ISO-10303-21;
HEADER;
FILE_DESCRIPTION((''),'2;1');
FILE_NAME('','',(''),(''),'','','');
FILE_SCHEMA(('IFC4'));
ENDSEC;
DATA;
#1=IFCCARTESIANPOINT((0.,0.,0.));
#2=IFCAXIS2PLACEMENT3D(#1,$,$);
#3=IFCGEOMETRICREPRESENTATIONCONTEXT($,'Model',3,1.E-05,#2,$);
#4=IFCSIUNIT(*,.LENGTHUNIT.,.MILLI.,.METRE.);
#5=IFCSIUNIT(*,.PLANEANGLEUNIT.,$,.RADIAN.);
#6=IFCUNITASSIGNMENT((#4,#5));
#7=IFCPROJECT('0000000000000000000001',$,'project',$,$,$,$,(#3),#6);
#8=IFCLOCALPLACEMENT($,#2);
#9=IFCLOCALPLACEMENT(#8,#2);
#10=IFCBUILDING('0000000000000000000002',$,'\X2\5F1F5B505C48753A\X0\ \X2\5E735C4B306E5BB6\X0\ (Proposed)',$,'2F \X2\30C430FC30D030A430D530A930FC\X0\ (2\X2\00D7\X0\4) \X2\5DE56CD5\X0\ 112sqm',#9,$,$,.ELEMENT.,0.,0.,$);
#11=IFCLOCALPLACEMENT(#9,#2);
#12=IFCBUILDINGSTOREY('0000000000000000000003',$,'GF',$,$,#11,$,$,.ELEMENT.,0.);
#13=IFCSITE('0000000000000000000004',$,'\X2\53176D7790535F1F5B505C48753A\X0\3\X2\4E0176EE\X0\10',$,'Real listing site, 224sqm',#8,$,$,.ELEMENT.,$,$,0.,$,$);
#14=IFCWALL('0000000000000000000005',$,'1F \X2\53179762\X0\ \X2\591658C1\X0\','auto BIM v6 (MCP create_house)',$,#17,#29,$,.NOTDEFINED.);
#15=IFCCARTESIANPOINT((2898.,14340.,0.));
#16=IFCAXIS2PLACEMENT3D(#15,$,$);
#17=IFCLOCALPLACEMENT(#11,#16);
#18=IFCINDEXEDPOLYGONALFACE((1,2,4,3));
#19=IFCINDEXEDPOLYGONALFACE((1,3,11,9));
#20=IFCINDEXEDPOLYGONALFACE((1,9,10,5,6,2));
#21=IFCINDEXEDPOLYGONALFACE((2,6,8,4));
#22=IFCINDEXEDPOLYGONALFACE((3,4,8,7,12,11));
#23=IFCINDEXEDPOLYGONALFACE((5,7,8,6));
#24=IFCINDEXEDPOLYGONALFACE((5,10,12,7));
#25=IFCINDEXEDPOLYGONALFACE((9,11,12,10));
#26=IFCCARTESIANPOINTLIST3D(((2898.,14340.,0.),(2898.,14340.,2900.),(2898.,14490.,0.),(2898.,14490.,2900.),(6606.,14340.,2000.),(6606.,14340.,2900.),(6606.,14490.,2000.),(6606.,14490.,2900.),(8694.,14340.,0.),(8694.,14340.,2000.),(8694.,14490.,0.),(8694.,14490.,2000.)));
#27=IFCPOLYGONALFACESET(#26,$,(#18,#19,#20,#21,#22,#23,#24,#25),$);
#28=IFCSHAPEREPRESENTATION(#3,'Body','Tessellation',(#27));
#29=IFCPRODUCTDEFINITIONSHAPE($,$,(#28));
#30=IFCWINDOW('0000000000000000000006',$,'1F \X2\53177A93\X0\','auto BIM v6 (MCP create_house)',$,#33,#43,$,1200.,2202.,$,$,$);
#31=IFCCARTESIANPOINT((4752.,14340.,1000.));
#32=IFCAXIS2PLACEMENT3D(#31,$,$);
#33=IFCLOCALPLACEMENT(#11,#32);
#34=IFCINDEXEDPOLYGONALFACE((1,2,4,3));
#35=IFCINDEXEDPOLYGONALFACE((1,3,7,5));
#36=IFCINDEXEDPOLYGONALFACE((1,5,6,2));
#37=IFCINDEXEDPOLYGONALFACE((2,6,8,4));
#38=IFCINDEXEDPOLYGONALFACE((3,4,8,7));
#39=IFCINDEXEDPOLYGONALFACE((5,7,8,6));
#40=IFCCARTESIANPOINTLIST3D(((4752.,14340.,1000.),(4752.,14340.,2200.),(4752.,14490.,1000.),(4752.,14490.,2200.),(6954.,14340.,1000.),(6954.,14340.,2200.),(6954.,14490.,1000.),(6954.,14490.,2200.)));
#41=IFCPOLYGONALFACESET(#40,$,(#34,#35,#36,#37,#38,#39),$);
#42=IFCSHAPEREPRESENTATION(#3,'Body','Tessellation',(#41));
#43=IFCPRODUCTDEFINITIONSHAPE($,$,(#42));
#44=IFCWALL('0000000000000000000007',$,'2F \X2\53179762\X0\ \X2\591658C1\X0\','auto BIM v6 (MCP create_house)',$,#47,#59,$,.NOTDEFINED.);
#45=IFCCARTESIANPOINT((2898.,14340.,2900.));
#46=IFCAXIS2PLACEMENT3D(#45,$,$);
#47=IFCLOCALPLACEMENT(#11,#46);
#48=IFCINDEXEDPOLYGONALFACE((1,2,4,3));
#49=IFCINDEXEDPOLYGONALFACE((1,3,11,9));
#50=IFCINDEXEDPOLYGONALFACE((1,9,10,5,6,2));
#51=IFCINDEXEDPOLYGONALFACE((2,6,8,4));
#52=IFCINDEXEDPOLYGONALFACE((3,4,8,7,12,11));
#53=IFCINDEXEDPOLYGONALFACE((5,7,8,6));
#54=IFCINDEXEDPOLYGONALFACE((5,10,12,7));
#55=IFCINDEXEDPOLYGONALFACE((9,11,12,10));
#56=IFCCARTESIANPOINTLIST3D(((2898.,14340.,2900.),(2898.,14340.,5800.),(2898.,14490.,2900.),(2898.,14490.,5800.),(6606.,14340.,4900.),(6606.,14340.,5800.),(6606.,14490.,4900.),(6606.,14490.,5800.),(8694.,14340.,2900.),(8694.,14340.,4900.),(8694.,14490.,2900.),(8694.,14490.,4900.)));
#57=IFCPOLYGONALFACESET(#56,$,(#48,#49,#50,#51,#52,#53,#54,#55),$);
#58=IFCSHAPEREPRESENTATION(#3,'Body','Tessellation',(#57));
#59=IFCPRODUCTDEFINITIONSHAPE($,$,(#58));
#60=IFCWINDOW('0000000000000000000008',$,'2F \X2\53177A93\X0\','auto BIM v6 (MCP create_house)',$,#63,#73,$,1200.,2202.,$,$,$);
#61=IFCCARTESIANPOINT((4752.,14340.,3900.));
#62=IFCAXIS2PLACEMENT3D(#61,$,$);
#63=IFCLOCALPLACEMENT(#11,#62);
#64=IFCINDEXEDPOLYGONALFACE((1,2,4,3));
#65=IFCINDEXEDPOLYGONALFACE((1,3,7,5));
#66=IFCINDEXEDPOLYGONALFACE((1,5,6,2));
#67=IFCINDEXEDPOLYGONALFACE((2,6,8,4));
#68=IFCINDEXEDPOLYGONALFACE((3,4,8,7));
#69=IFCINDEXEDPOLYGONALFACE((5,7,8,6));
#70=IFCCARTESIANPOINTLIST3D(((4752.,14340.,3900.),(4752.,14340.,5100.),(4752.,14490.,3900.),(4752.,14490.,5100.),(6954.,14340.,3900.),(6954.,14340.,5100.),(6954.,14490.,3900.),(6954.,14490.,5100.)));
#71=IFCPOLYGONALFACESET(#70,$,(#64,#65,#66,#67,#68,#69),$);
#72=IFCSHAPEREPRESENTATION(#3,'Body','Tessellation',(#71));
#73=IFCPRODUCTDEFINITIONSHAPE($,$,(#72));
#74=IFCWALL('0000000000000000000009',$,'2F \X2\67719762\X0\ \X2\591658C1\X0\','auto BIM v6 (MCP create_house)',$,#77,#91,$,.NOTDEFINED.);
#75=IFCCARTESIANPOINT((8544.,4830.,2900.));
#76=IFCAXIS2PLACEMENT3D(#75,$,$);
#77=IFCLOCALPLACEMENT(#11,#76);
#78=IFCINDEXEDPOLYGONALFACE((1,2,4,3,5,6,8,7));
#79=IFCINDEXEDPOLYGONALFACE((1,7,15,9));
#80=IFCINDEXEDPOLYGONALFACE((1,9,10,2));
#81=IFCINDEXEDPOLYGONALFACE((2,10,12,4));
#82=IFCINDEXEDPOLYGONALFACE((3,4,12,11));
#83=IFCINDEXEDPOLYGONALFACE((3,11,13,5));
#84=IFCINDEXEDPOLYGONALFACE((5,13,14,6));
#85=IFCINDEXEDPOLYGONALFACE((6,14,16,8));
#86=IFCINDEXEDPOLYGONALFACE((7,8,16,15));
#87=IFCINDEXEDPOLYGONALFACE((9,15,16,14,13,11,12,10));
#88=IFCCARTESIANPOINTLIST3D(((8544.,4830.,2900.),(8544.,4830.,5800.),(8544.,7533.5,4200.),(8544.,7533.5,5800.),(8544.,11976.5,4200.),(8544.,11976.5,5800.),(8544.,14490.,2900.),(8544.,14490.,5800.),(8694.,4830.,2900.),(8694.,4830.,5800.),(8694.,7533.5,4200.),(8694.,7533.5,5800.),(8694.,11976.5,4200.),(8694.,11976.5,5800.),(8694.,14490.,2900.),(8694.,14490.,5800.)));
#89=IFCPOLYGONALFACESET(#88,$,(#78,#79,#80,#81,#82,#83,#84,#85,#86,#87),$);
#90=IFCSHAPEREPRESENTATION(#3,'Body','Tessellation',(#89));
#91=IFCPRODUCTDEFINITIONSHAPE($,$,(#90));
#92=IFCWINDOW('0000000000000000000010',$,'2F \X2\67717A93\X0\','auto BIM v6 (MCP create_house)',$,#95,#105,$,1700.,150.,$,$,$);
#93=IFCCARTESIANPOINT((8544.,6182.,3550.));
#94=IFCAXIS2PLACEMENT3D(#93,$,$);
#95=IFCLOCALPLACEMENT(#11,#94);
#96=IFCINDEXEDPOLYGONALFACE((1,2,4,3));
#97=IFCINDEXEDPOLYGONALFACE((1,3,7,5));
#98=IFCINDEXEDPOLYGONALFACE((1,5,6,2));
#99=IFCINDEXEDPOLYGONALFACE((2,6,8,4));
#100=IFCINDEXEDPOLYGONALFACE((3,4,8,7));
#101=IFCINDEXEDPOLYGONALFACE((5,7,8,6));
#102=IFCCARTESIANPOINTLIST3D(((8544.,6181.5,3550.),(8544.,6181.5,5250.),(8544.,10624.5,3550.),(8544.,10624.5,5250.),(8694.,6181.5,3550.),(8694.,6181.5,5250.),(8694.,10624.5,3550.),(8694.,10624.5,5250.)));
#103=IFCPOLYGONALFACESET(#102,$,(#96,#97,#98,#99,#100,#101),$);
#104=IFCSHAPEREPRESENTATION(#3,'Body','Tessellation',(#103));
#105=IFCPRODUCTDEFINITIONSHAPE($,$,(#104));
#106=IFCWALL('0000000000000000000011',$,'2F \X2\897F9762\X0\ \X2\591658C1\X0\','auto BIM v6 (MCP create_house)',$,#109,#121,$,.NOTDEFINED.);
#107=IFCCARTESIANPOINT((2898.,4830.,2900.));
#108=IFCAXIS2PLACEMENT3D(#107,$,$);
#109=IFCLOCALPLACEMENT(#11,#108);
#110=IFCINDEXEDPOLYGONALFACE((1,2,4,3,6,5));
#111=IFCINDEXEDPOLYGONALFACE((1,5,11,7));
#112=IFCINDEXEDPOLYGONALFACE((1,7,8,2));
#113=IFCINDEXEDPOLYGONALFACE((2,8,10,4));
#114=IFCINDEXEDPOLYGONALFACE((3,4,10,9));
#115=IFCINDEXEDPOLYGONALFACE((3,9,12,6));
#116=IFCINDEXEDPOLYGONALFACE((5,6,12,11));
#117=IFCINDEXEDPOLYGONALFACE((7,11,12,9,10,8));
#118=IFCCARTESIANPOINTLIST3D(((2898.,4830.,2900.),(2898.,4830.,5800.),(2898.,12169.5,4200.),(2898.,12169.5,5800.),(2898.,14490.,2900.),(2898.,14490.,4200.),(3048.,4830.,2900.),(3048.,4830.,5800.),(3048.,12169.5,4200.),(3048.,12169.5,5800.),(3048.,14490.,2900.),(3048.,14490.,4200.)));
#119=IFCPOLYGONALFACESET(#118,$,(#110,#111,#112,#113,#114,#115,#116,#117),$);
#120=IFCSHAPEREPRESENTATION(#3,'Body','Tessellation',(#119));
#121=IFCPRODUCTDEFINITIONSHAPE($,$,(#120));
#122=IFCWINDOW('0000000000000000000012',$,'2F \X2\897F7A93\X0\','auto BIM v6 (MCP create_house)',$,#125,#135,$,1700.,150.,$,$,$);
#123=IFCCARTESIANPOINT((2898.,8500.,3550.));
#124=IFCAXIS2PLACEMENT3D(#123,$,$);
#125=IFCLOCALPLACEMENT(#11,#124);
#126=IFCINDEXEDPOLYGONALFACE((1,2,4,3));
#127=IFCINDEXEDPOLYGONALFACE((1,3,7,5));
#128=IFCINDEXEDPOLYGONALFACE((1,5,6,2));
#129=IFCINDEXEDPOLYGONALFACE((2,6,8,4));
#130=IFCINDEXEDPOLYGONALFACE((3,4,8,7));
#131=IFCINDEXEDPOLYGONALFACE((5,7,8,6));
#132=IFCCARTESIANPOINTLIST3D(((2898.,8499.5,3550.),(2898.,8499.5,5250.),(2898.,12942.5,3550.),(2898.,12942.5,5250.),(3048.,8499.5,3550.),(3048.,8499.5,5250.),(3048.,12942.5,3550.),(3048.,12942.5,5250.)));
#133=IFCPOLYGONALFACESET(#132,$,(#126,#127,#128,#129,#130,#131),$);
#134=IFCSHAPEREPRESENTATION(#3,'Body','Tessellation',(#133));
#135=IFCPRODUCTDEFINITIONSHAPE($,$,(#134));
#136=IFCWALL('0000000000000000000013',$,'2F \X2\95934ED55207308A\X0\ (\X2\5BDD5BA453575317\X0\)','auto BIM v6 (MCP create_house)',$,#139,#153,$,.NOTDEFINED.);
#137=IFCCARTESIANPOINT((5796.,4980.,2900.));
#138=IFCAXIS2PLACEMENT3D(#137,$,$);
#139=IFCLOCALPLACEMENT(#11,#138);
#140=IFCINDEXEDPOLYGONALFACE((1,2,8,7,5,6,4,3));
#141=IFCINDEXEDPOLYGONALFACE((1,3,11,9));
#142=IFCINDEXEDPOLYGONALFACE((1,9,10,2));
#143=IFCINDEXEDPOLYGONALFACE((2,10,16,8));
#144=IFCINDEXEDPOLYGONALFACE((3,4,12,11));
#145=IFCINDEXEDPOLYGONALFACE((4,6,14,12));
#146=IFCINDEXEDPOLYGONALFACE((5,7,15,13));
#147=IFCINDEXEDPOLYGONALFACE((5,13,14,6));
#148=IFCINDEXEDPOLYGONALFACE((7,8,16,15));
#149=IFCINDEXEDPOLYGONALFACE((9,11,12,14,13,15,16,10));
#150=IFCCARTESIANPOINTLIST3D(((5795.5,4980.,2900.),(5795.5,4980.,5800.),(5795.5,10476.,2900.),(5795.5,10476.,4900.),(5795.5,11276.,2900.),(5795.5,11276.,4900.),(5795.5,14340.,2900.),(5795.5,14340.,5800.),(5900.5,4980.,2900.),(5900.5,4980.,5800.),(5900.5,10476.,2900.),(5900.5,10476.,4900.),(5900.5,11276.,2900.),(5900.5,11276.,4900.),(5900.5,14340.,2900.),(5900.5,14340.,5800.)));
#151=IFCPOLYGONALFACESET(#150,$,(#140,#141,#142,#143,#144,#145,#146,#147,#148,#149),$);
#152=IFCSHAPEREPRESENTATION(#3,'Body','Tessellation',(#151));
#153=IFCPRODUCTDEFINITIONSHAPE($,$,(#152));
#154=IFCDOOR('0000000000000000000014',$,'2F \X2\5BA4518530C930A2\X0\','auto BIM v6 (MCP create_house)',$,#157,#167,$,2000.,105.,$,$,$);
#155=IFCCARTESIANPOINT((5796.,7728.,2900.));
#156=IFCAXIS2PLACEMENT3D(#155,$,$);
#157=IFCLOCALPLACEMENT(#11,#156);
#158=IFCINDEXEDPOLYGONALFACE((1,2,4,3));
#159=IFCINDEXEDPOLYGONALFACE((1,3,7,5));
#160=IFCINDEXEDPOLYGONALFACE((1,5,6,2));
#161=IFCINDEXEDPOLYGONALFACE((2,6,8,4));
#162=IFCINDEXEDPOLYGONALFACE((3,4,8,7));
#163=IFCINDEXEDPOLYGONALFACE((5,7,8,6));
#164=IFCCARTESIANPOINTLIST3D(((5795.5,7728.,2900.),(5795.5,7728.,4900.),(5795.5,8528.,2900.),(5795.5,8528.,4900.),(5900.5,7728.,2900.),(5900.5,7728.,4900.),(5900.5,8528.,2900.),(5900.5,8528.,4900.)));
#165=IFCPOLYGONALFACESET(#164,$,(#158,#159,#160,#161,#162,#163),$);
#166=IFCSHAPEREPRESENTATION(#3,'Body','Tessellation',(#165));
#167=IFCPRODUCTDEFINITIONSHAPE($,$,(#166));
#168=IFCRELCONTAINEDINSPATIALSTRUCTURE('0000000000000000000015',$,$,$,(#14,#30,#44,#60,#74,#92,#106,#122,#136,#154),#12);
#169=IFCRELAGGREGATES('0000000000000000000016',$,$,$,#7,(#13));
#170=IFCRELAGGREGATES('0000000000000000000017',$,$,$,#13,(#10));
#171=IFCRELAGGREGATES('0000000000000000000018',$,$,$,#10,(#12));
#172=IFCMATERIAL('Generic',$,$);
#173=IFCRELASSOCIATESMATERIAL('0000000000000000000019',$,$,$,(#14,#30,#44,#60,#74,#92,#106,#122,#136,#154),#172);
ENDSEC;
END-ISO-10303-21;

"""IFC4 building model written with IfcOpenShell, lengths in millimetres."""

from ifc_helpers import new_model, si_unit, frame, frame_2d, origin, place, context, project, spatial, rectangle, extrude, material, element, fill, save


model = new_model("IFC4")

# Units and contexts
model_context = context("Model", 3, precision=1e-05, world=origin())
ifc_project = project(units=[si_unit("LENGTHUNIT", "METRE", prefix="MILLI"), si_unit("PLANEANGLEUNIT", "RADIAN")], contexts=[model_context])

# Site, building, storey
site_placement = place(None, origin())
site = spatial("IfcSite", under=ifc_project, at=site_placement, Name="北海道弟子屈町3丁目10", ObjectType="Real listing site, 224sqm", CompositionType="ELEMENT", RefElevation=0.0)
building_placement = place(site_placement, origin())
building = spatial("IfcBuilding", under=site, at=building_placement, Name="弟子屈町 平屋の家 (Proposed)", ObjectType="2F ツーバイフォー (2×4) 工法 112sqm", CompositionType="ELEMENT", ElevationOfRefHeight=0.0, ElevationOfTerrain=0.0)
storey_placement = place(building_placement, origin())
storey = spatial("IfcBuildingStorey", under=building, at=storey_placement, Name="GF", CompositionType="ELEMENT", Elevation=0.0)

# Wall, opening, window
ifc_material = material(Name="Generic")
wall_1_placement = place(storey_placement, frame((2898.0, 14340.0, 0.0)))
wall_1 = element("IfcWall", 1, at=wall_1_placement, inside=storey, material=ifc_material, Name="1F 北面 外壁", Description="auto BIM v6 (MCP create_house)", PredefinedType="NOTDEFINED", context=model_context, shape_type="SweptSolid", body=[
    extrude(rectangle(XDim=5796.0, YDim=150.0, at=frame_2d((2898.0, 75.0))), frame((2898.0, 14340.0, 0.0)), (0.0, 0.0, 1.0), 2900.0),
])
opening_1_placement = place(storey_placement, frame((4752.0, 14340.0, 1000.0)))
opening_1 = element("IfcOpeningElement", 2, at=opening_1_placement, cuts=wall_1, PredefinedType="NOTDEFINED", context=model_context, shape_type="SweptSolid", body=[
    extrude(rectangle(XDim=2202.0, YDim=150.0, at=frame_2d((1101.0, 75.0))), frame((4752.0, 14340.0, 1000.0)), (0.0, 0.0, 1.0), 1200.0),
])
window_1_placement = place(storey_placement, frame((4752.0, 14340.0, 1000.0)))
window_1 = element("IfcWindow", 3, at=window_1_placement, inside=storey, material=ifc_material, Name="1F 北窓", Description="auto BIM v6 (MCP create_house)", OverallHeight=1200.0, OverallWidth=2202.0, context=model_context, shape_type="SweptSolid", body=[
    extrude(rectangle(XDim=2202.0, YDim=150.0, at=frame_2d((1101.0, 75.0))), frame((4752.0, 14340.0, 1000.0)), (0.0, 0.0, 1.0), 1200.0),
])
fill(opening_1, window_1)

# Walls, openings, windows
wall_2_placement = place(storey_placement, frame((2898.0, 14340.0, 2900.0)))
wall_2 = element("IfcWall", 4, at=wall_2_placement, inside=storey, material=ifc_material, Name="2F 北面 外壁", Description="auto BIM v6 (MCP create_house)", PredefinedType="NOTDEFINED", context=model_context, shape_type="SweptSolid", body=[
    extrude(rectangle(XDim=5796.0, YDim=150.0, at=frame_2d((2898.0, 75.0))), frame((2898.0, 14340.0, 2900.0)), (0.0, 0.0, 1.0), 2900.0),
])
opening_2_placement = place(storey_placement, frame((4752.0, 14340.0, 3900.0)))
opening_2 = element("IfcOpeningElement", 5, at=opening_2_placement, cuts=wall_2, PredefinedType="NOTDEFINED", context=model_context, shape_type="SweptSolid", body=[
    extrude(rectangle(XDim=2202.0, YDim=150.0, at=frame_2d((1101.0, 75.0))), frame((4752.0, 14340.0, 3900.0)), (0.0, 0.0, 1.0), 1200.0),
])
window_2_placement = place(storey_placement, frame((4752.0, 14340.0, 3900.0)))
window_2 = element("IfcWindow", 6, at=window_2_placement, inside=storey, material=ifc_material, Name="2F 北窓", Description="auto BIM v6 (MCP create_house)", OverallHeight=1200.0, OverallWidth=2202.0, context=model_context, shape_type="SweptSolid", body=[
    extrude(rectangle(XDim=2202.0, YDim=150.0, at=frame_2d((1101.0, 75.0))), frame((4752.0, 14340.0, 3900.0)), (0.0, 0.0, 1.0), 1200.0),
])
fill(opening_2, window_2)
wall_3_placement = place(storey_placement, frame((8544.0, 4830.0, 2900.0)))
wall_3 = element("IfcWall", 7, at=wall_3_placement, inside=storey, material=ifc_material, Name="2F 東面 外壁", Description="auto BIM v6 (MCP create_house)", PredefinedType="NOTDEFINED", context=model_context, shape_type="SweptSolid", body=[
    extrude(rectangle(XDim=150.0, YDim=9660.0, at=frame_2d((75.0, 4830.0))), frame((8544.0, 4830.0, 2900.0)), (0.0, 0.0, 1.0), 2900.0),
])
opening_3_placement = place(storey_placement, frame((8544.0, 6182.0, 3550.0)))
opening_3 = element("IfcOpeningElement", 8, at=opening_3_placement, cuts=wall_3, PredefinedType="NOTDEFINED", context=model_context, shape_type="SweptSolid", body=[
    extrude(rectangle(XDim=150.0, YDim=4443.0, at=frame_2d((75.0, 2221.0))), frame((8544.0, 6182.0, 3550.0)), (0.0, 0.0, 1.0), 1700.0),
])
window_3_placement = place(storey_placement, frame((8544.0, 6182.0, 3550.0)))
window_3 = element("IfcWindow", 9, at=window_3_placement, inside=storey, material=ifc_material, Name="2F 東窓", Description="auto BIM v6 (MCP create_house)", OverallHeight=1700.0, OverallWidth=150.0, context=model_context, shape_type="SweptSolid", body=[
    extrude(rectangle(XDim=150.0, YDim=4443.0, at=frame_2d((75.0, 2221.0))), frame((8544.0, 6182.0, 3550.0)), (0.0, 0.0, 1.0), 1700.0),
])
fill(opening_3, window_3)
wall_4_placement = place(storey_placement, frame((2898.0, 4830.0, 2900.0)))
wall_4 = element("IfcWall", 10, at=wall_4_placement, inside=storey, material=ifc_material, Name="2F 西面 外壁", Description="auto BIM v6 (MCP create_house)", PredefinedType="NOTDEFINED", context=model_context, shape_type="SweptSolid", body=[
    extrude(rectangle(XDim=150.0, YDim=9660.0, at=frame_2d((75.0, 4830.0))), frame((2898.0, 4830.0, 2900.0)), (0.0, 0.0, 1.0), 2900.0),
])
opening_4_placement = place(storey_placement, frame((2898.0, 8500.0, 3550.0)))
opening_4 = element("IfcOpeningElement", 11, at=opening_4_placement, cuts=wall_4, PredefinedType="NOTDEFINED", context=model_context, shape_type="SweptSolid", body=[
    extrude(rectangle(XDim=150.0, YDim=4443.0, at=frame_2d((75.0, 2221.0))), frame((2898.0, 8500.0, 3550.0)), (0.0, 0.0, 1.0), 1700.0),
])
window_4_placement = place(storey_placement, frame((2898.0, 8500.0, 3550.0)))
window_4 = element("IfcWindow", 12, at=window_4_placement, inside=storey, material=ifc_material, Name="2F 西窓", Description="auto BIM v6 (MCP create_house)", OverallHeight=1700.0, OverallWidth=150.0, context=model_context, shape_type="SweptSolid", body=[
    extrude(rectangle(XDim=150.0, YDim=4443.0, at=frame_2d((75.0, 2221.0))), frame((2898.0, 8500.0, 3550.0)), (0.0, 0.0, 1.0), 1700.0),
])
fill(opening_4, window_4)

# Wall, opening, door
wall_5_placement = place(storey_placement, frame((5796.0, 4980.0, 2900.0)))
wall_5 = element("IfcWall", 13, at=wall_5_placement, inside=storey, material=ifc_material, Name="2F 間仕切り (寝室南北)", Description="auto BIM v6 (MCP create_house)", PredefinedType="NOTDEFINED", context=model_context, shape_type="SweptSolid", body=[
    extrude(rectangle(XDim=105.0, YDim=9360.0, at=frame_2d((52.0, 4680.0))), frame((5796.0, 4980.0, 2900.0)), (0.0, 0.0, 1.0), 2900.0),
])
opening_5_placement = place(storey_placement, frame((5796.0, 7728.0, 2900.0)))
opening_5 = element("IfcOpeningElement", 14, at=opening_5_placement, cuts=wall_5, PredefinedType="NOTDEFINED", context=model_context, shape_type="SweptSolid", body=[
    extrude(rectangle(XDim=105.0, YDim=800.0, at=frame_2d((52.0, 400.0))), frame((5796.0, 7728.0, 2900.0)), (0.0, 0.0, 1.0), 2000.0),
])
door_placement = place(storey_placement, frame((5796.0, 7728.0, 2900.0)))
door = element("IfcDoor", 15, at=door_placement, inside=storey, material=ifc_material, Name="2F 室内ドア", Description="auto BIM v6 (MCP create_house)", OverallHeight=2000.0, OverallWidth=105.0, context=model_context, shape_type="SweptSolid", body=[
    extrude(rectangle(XDim=105.0, YDim=800.0, at=frame_2d((52.0, 400.0))), frame((5796.0, 7728.0, 2900.0)), (0.0, 0.0, 1.0), 2000.0),
])
fill(opening_5, door)

save(model, "model.ifc")
